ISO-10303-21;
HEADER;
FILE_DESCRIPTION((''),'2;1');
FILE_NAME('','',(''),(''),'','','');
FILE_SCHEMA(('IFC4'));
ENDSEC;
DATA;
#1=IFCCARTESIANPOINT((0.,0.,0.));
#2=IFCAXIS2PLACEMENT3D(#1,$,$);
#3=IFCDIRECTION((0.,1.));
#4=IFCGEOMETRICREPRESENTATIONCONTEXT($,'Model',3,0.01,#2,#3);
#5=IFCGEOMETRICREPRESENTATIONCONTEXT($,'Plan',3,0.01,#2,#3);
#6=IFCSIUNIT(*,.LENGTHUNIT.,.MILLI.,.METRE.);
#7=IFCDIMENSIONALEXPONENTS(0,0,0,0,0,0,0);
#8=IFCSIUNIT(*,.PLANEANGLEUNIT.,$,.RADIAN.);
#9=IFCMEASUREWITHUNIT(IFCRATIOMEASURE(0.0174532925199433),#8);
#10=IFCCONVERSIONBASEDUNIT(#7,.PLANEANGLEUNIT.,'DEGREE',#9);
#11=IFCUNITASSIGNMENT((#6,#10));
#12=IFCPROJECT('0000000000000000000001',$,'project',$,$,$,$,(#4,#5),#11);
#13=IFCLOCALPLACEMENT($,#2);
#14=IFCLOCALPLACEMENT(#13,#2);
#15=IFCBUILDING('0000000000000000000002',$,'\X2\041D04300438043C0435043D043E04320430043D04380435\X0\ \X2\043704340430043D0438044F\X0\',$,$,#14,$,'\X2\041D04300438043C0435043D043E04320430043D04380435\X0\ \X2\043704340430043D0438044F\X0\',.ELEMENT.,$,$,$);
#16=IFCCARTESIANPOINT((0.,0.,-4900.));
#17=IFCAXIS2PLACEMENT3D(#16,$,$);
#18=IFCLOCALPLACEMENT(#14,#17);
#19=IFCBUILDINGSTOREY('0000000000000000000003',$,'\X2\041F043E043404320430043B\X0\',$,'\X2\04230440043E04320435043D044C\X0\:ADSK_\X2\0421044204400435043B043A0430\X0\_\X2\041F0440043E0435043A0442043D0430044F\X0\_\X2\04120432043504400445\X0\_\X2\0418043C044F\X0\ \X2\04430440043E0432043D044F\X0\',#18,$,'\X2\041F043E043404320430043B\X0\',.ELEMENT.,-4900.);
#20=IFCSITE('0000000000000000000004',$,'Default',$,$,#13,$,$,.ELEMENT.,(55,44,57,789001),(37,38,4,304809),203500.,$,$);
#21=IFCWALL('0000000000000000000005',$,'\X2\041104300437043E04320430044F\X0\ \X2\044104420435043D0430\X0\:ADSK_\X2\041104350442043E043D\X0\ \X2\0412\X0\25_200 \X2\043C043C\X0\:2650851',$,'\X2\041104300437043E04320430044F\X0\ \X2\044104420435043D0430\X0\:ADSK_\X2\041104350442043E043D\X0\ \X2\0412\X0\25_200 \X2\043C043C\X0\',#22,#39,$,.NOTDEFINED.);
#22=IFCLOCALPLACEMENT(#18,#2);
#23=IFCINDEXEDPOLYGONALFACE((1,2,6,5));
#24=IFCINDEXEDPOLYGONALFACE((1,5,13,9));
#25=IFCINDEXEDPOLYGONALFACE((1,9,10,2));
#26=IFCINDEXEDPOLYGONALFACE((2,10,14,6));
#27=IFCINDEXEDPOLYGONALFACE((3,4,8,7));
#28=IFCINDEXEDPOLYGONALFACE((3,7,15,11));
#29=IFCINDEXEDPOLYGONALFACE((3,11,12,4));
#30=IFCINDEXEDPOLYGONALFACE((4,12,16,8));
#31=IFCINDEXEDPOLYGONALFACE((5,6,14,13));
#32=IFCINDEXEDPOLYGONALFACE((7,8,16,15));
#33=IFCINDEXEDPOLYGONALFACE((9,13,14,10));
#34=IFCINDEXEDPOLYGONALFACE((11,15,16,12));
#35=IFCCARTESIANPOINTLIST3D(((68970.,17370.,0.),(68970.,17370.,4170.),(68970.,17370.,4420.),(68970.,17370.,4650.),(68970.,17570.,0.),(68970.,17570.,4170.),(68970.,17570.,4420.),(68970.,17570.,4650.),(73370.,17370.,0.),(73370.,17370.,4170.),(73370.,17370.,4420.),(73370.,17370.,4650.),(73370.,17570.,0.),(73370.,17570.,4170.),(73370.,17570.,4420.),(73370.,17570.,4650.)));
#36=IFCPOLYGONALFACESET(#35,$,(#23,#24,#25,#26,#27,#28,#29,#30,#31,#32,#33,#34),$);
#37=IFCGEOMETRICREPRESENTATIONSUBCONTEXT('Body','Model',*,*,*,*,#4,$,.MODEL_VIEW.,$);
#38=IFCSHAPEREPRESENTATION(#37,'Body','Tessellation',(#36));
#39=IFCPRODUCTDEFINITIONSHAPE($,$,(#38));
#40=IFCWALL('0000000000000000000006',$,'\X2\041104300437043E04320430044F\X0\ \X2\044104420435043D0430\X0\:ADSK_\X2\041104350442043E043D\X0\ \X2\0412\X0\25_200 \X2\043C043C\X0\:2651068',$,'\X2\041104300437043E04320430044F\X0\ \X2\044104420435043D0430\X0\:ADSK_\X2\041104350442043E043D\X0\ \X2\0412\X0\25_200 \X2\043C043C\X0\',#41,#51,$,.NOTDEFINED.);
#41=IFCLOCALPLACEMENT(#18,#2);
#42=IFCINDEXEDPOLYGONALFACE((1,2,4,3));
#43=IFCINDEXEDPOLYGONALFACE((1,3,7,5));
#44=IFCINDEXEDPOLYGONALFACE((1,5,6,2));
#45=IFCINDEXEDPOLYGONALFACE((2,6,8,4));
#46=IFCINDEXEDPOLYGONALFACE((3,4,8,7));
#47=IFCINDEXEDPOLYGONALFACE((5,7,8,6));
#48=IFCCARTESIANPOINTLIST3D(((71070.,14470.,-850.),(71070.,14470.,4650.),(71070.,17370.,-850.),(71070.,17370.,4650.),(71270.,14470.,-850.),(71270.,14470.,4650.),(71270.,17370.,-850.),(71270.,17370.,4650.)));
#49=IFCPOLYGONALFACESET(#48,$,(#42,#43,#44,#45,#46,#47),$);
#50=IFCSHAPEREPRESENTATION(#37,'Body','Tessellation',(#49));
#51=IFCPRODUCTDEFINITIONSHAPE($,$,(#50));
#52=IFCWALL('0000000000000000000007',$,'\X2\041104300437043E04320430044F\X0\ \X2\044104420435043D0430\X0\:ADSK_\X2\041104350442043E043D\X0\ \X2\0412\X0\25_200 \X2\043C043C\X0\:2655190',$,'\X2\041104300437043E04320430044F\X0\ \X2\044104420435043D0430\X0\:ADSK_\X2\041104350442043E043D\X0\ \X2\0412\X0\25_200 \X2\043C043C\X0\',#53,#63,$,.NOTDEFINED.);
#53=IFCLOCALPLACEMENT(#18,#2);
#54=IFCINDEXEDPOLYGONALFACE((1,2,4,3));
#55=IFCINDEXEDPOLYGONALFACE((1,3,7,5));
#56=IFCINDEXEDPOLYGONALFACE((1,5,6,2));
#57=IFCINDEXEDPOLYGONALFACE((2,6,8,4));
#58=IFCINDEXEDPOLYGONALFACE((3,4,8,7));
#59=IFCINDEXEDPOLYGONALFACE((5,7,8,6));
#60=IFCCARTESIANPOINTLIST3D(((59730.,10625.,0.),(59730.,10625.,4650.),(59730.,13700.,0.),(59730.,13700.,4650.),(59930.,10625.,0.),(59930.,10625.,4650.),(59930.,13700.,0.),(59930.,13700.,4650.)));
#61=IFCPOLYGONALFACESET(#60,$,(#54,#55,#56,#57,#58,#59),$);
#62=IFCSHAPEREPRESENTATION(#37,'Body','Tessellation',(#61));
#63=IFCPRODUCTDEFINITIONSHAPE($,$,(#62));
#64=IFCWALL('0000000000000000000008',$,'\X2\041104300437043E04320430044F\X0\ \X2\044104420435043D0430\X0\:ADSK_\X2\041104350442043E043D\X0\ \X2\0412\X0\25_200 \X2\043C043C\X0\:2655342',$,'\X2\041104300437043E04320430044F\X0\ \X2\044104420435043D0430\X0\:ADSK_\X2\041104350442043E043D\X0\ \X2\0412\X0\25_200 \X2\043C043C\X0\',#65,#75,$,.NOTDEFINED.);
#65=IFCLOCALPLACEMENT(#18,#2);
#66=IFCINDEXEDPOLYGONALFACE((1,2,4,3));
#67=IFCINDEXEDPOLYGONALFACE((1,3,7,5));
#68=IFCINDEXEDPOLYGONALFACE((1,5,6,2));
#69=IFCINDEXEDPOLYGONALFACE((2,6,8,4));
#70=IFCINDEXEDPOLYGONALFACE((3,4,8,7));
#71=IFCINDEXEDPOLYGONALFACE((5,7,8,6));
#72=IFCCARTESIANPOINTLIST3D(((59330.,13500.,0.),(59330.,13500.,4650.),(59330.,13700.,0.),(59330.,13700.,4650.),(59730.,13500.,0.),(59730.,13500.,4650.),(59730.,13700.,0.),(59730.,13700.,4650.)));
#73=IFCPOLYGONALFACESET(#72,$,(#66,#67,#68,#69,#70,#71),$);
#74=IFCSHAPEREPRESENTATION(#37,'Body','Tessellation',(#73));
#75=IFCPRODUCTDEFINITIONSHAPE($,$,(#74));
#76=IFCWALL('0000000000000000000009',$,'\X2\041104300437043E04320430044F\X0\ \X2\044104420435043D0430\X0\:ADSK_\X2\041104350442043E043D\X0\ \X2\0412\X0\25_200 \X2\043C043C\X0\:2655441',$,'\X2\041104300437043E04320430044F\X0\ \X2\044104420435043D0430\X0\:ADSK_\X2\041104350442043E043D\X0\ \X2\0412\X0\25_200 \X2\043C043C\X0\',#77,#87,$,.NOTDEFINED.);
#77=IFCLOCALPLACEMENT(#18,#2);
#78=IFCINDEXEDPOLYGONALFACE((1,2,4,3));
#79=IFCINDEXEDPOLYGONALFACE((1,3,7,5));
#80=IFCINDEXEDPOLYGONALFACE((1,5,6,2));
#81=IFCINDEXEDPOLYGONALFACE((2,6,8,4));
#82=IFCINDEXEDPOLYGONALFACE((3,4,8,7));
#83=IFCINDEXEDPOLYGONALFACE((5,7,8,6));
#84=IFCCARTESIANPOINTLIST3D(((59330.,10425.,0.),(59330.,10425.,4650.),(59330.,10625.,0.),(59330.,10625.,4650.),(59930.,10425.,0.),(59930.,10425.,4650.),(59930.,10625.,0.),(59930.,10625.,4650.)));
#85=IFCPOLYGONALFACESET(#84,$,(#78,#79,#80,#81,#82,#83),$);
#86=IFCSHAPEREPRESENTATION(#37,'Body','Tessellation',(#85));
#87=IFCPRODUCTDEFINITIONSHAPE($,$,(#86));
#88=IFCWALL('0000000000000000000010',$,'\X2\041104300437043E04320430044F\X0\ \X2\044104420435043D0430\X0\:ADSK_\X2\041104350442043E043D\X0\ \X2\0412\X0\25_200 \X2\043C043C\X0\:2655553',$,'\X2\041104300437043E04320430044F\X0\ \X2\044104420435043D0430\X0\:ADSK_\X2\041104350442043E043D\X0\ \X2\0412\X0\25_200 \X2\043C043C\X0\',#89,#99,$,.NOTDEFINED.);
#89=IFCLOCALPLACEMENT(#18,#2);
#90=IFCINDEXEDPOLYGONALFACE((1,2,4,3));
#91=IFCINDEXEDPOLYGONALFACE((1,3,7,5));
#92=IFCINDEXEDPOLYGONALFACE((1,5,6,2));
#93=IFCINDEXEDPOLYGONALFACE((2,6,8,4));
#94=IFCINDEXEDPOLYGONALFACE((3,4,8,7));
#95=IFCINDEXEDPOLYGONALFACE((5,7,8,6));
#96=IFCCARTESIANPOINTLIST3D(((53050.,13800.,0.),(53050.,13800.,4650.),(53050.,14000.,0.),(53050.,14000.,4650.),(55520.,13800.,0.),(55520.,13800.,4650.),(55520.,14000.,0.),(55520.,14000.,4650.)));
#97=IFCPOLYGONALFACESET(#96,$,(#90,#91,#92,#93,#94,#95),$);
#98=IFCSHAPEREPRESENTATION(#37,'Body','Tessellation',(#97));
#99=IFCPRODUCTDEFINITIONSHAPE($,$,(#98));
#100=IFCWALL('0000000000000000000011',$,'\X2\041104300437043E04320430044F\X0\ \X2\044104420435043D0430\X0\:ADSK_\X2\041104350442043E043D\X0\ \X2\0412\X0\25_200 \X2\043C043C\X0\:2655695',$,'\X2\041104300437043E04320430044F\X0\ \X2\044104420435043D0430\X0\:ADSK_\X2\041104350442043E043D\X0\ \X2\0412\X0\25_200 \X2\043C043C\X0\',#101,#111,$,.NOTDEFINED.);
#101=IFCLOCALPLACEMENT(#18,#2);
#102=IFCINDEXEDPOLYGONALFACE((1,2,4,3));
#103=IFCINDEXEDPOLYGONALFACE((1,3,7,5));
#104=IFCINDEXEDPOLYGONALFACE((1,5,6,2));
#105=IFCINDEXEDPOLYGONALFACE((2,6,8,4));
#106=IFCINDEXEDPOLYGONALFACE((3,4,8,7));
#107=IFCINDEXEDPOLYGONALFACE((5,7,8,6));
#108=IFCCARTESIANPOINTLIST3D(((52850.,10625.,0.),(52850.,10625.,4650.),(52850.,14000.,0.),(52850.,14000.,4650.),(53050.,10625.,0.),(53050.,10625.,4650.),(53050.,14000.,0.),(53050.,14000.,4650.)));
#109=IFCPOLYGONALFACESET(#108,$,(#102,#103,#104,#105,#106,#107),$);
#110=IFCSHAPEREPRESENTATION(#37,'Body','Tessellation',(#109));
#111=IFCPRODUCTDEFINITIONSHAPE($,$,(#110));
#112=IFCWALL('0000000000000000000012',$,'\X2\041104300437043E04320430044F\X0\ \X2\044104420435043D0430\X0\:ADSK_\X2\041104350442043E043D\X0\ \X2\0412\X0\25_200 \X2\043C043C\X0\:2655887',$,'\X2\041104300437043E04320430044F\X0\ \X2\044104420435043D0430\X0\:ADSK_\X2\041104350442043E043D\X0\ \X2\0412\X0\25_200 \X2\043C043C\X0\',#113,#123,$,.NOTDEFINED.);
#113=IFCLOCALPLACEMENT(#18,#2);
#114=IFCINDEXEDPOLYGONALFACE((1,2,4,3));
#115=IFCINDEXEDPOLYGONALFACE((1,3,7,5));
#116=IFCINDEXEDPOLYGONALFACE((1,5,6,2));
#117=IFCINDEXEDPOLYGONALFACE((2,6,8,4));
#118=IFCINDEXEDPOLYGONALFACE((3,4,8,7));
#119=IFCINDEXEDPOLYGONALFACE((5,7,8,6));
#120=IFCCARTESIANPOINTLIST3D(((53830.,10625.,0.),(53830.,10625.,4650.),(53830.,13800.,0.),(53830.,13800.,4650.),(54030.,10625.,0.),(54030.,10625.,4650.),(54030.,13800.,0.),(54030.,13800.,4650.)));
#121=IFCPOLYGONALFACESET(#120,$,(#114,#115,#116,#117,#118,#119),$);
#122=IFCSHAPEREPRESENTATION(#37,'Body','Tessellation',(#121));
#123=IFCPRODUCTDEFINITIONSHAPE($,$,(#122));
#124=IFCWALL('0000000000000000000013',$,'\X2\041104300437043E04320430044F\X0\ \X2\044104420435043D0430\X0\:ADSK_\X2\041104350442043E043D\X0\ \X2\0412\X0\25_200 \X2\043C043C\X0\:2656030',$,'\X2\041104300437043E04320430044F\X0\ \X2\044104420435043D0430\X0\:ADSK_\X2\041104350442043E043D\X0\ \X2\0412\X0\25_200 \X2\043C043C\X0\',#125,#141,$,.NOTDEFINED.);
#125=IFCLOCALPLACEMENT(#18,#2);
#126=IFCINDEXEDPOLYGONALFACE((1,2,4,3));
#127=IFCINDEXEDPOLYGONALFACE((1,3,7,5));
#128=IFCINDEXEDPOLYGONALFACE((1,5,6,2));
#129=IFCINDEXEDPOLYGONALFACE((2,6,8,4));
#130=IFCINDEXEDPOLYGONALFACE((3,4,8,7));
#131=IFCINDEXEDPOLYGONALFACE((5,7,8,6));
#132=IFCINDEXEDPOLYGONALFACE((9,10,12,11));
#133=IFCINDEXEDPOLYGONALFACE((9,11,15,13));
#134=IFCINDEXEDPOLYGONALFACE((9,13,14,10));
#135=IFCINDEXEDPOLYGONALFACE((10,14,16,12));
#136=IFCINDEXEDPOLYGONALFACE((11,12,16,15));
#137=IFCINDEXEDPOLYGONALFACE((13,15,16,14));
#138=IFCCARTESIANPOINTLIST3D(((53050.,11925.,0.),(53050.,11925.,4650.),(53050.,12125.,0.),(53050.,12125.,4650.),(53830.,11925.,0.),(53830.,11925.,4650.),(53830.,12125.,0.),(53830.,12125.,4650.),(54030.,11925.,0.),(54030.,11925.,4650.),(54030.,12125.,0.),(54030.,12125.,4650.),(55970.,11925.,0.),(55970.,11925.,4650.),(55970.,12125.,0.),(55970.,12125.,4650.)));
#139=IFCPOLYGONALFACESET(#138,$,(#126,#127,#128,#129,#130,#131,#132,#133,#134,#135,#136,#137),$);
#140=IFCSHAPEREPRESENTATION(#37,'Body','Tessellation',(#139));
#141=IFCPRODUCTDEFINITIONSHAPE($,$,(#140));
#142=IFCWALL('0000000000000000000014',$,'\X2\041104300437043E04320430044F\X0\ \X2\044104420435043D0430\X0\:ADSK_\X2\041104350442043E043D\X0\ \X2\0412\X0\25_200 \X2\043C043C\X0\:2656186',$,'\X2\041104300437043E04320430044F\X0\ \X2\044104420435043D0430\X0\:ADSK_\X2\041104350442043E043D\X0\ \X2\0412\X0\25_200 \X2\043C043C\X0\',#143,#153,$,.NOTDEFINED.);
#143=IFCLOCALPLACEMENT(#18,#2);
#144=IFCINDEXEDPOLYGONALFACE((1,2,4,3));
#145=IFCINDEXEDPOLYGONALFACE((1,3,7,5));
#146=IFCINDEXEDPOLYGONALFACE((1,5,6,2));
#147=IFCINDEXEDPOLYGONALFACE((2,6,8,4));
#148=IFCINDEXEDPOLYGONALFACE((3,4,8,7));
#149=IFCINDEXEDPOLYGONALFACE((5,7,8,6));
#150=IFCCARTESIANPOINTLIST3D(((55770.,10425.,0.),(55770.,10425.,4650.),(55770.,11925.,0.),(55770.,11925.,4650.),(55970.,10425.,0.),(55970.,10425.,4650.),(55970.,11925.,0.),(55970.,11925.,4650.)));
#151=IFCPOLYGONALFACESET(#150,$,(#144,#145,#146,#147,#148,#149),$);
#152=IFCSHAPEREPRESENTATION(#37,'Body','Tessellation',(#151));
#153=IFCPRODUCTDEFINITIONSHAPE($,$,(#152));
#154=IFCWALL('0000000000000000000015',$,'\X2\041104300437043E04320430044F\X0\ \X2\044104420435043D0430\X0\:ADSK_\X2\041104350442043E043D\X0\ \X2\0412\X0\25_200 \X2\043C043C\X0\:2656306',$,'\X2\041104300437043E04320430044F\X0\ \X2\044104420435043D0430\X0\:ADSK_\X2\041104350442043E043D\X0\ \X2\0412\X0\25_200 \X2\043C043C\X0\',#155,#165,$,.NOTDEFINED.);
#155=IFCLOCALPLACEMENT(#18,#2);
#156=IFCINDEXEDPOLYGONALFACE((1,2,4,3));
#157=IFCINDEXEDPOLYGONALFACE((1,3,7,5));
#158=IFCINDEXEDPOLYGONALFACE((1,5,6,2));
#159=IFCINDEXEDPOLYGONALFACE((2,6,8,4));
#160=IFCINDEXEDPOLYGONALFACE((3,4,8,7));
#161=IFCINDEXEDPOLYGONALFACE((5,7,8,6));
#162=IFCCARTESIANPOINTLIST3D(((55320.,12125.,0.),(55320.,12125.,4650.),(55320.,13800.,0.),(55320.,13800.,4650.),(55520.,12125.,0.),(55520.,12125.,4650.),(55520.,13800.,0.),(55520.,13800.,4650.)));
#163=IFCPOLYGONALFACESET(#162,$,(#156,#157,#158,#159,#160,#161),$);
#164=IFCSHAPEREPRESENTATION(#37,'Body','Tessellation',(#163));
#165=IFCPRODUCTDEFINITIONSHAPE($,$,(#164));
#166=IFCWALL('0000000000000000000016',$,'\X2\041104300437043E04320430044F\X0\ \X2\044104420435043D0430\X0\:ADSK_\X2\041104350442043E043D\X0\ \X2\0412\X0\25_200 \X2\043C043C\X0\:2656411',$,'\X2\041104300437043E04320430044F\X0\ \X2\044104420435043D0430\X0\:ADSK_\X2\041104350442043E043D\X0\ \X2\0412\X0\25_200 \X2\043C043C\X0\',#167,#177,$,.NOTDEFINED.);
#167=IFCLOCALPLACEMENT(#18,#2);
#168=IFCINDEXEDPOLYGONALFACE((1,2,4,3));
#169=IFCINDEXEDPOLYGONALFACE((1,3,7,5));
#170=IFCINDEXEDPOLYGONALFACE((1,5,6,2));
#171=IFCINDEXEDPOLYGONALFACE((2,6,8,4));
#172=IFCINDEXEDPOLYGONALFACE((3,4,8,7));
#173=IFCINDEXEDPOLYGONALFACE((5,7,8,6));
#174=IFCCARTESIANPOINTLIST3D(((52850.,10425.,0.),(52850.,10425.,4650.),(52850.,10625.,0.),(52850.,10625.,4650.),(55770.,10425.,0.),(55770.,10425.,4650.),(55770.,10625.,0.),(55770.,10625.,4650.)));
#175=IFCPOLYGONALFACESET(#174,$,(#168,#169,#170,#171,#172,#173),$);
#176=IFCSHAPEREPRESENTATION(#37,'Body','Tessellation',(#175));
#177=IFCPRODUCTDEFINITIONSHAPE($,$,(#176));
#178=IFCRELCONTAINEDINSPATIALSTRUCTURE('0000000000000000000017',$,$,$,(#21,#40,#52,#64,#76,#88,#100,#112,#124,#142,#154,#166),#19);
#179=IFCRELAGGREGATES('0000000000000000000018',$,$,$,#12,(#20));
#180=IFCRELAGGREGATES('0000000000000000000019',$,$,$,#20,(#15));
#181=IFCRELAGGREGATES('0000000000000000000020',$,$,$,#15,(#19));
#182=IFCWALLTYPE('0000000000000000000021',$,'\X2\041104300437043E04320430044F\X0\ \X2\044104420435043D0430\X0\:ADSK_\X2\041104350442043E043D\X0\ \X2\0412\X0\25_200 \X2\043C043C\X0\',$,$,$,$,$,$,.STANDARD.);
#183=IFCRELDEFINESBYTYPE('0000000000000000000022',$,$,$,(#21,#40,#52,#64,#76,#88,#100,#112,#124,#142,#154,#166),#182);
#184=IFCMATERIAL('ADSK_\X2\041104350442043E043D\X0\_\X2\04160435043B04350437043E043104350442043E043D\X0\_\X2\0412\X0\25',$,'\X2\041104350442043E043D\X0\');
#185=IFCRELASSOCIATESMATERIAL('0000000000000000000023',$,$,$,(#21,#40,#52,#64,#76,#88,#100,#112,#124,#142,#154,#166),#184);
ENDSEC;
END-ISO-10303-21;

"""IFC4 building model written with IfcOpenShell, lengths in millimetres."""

from ifc_helpers import new_model, entity, si_unit, converted_unit, direction, frame, origin, place, context, subcontext, project, spatial, indexed_curve, outline, extrude, material, type_object, element, save


model = new_model("IFC4")

# Units and contexts
model_context = context("Model", 3, precision=0.01, world=origin(), true_north=direction((0.0, 1.0)))
plan_context = context("Plan", 3, precision=0.01, world=origin(), true_north=direction((0.0, 1.0)))
body_context = subcontext(model_context, "Body", "Model", "MODEL_VIEW")
ifc_project = project(units=[si_unit("LENGTHUNIT", "METRE", prefix="MILLI"), converted_unit("PLANEANGLEUNIT", "DEGREE", entity("IfcRatioMeasure", 0.0174532925199433), si_unit("PLANEANGLEUNIT", "RADIAN"), dimensions=[0, 0, 0, 0, 0, 0, 0])], contexts=[model_context, plan_context])

# Site, building, storey
site_placement = place(None, origin())
site = spatial("IfcSite", under=ifc_project, at=site_placement, Name="Default", CompositionType="ELEMENT", RefLatitude=(55, 44, 57, 789001), RefLongitude=(37, 38, 4, 304809), RefElevation=203500.0)
building_placement = place(site_placement, origin())
building = spatial("IfcBuilding", under=site, at=building_placement, Name="Наименование здания", LongName="Наименование здания", CompositionType="ELEMENT")
storey_placement = place(building_placement, frame((0.0, 0.0, -4900.0)))
storey = spatial("IfcBuildingStorey", under=building, at=storey_placement, Name="Подвал", ObjectType="Уровень:ADSK_Стрелка_Проектная_Вверх_Имя уровня", LongName="Подвал", CompositionType="ELEMENT", Elevation=-4900.0)

# Wall, opening
ifc_material = material(Name="ADSK_Бетон_Железобетон_В25", Category="Бетон")
wall_type_1 = type_object("IfcWallType", Name="Базовая стена:ADSK_Бетон В25_200 мм", PredefinedType="STANDARD")
placement_1 = place(storey_placement, frame((73370.0, 17470.0, 0.0), z_axis=(0.0, 0.0, 1.0), x_axis=(-1.0, 0.0, 0.0)))
wall_1 = element("IfcWall", 1, at=placement_1, inside=storey, type_object=wall_type_1, material=ifc_material, Name="Базовая стена:ADSK_Бетон В25_200 мм:2650851", ObjectType="Базовая стена:ADSK_Бетон В25_200 мм", PredefinedType="NOTDEFINED", context=body_context, shape_type="SweptSolid", body=[
    extrude(outline(indexed_curve([(4400.0, 100.0), (0.0, 100.0), (0.0, -100.0), (4400.0, -100.0), (4400.0, 100.0)], self_intersect=False)), origin(), (0.0, 0.0, 1.0), 4650.0),
])
element("IfcOpeningElement", 2, at=placement_1, cuts=wall_1, PredefinedType="OPENING", context=body_context, shape_type="SweptSolid", body=[
    extrude(outline(indexed_curve([(-2200.0, -100.0), (2200.0, -100.0), (2200.0, 100.0), (-2200.0, 100.0), (-2200.0, -100.0)], self_intersect=False)), frame((2200.0, 0.0, 4170.0)), (0.0, 0.0, 1.0), 250.0),
])

# Walls
wall_2_placement = place(storey_placement, frame((71170.0, 14470.0, -850.0), z_axis=(0.0, 0.0, 1.0), x_axis=(0.0, 1.0, 0.0)))
element("IfcWall", 3, at=wall_2_placement, inside=storey, type_object=wall_type_1, material=ifc_material, Name="Базовая стена:ADSK_Бетон В25_200 мм:2651068", ObjectType="Базовая стена:ADSK_Бетон В25_200 мм", PredefinedType="NOTDEFINED", context=body_context, shape_type="SweptSolid", body=[
    extrude(outline(indexed_curve([(2900.0, 100.0), (0.0, 100.0), (0.0, -100.0), (2900.0, -100.0), (2900.0, 100.0)], self_intersect=False)), origin(), (0.0, 0.0, 1.0), 5500.0),
])
wall_3_placement = place(storey_placement, frame((59830.0, 10625.0, 0.0), z_axis=(0.0, 0.0, 1.0), x_axis=(0.0, 1.0, 0.0)))
element("IfcWall", 4, at=wall_3_placement, inside=storey, type_object=wall_type_1, material=ifc_material, Name="Базовая стена:ADSK_Бетон В25_200 мм:2655190", ObjectType="Базовая стена:ADSK_Бетон В25_200 мм", PredefinedType="NOTDEFINED", context=body_context, shape_type="SweptSolid", body=[
    extrude(outline(indexed_curve([(3075.0, 100.0), (0.0, 100.0), (0.0, -100.0), (3075.0, -100.0), (3075.0, 100.0)], self_intersect=False)), origin(), (0.0, 0.0, 1.0), 4650.0),
])
wall_4_placement = place(storey_placement, frame((59730.0, 13600.0, 0.0), z_axis=(0.0, 0.0, 1.0), x_axis=(-1.0, 0.0, 0.0)))
element("IfcWall", 5, at=wall_4_placement, inside=storey, type_object=wall_type_1, material=ifc_material, Name="Базовая стена:ADSK_Бетон В25_200 мм:2655342", ObjectType="Базовая стена:ADSK_Бетон В25_200 мм", PredefinedType="NOTDEFINED", context=body_context, shape_type="SweptSolid", body=[
    extrude(outline(indexed_curve([(400.0, 100.0), (0.0, 100.0), (0.0, -100.0), (400.0, -100.0), (400.0, 100.0)], self_intersect=False)), origin(), (0.0, 0.0, 1.0), 4650.0),
])
wall_5_placement = place(storey_placement, frame((59930.0, 10525.0, 0.0), z_axis=(0.0, 0.0, 1.0), x_axis=(-1.0, 0.0, 0.0)))
element("IfcWall", 6, at=wall_5_placement, inside=storey, type_object=wall_type_1, material=ifc_material, Name="Базовая стена:ADSK_Бетон В25_200 мм:2655441", ObjectType="Базовая стена:ADSK_Бетон В25_200 мм", PredefinedType="NOTDEFINED", context=body_context, shape_type="SweptSolid", body=[
    extrude(outline(indexed_curve([(600.0, 100.0), (0.0, 100.0), (0.0, -100.0), (600.0, -100.0), (600.0, 100.0)], self_intersect=False)), origin(), (0.0, 0.0, 1.0), 4650.0),
])
wall_6_placement = place(storey_placement, frame((55520.0, 13900.0, 0.0), z_axis=(0.0, 0.0, 1.0), x_axis=(-1.0, 0.0, 0.0)))
element("IfcWall", 7, at=wall_6_placement, inside=storey, type_object=wall_type_1, material=ifc_material, Name="Базовая стена:ADSK_Бетон В25_200 мм:2655553", ObjectType="Базовая стена:ADSK_Бетон В25_200 мм", PredefinedType="NOTDEFINED", context=body_context, shape_type="SweptSolid", body=[
    extrude(outline(indexed_curve([(2470.0, 100.0), (0.0, 100.0), (0.0, -100.0), (2470.0, -100.0), (2470.0, 100.0)], self_intersect=False)), origin(), (0.0, 0.0, 1.0), 4650.0),
])
wall_7_placement = place(storey_placement, frame((52950.0, 14000.0, 0.0), z_axis=(0.0, 0.0, 1.0), x_axis=(0.0, -1.0, 0.0)))
element("IfcWall", 8, at=wall_7_placement, inside=storey, type_object=wall_type_1, material=ifc_material, Name="Базовая стена:ADSK_Бетон В25_200 мм:2655695", ObjectType="Базовая стена:ADSK_Бетон В25_200 мм", PredefinedType="NOTDEFINED", context=body_context, shape_type="SweptSolid", body=[
    extrude(outline(indexed_curve([(3375.0, 100.0), (0.0, 100.0), (0.0, -100.0), (3375.0, -100.0), (3375.0, 100.0)], self_intersect=False)), origin(), (0.0, 0.0, 1.0), 4650.0),
])
wall_8_placement = place(storey_placement, frame((53930.0, 13800.0, 0.0), z_axis=(0.0, 0.0, 1.0), x_axis=(0.0, -1.0, 0.0)))
element("IfcWall", 9, at=wall_8_placement, inside=storey, type_object=wall_type_1, material=ifc_material, Name="Базовая стена:ADSK_Бетон В25_200 мм:2655887", ObjectType="Базовая стена:ADSK_Бетон В25_200 мм", PredefinedType="NOTDEFINED", context=body_context, shape_type="SweptSolid", body=[
    extrude(outline(indexed_curve([(3175.0, 100.0), (0.0, 100.0), (0.0, -100.0), (3175.0, -100.0), (3175.0, 100.0)], self_intersect=False)), origin(), (0.0, 0.0, 1.0), 4650.0),
])

# Wall, opening
placement_2 = place(storey_placement, frame((53050.0, 12025.0, 0.0)))
wall_9 = element("IfcWall", 10, at=placement_2, inside=storey, type_object=wall_type_1, material=ifc_material, Name="Базовая стена:ADSK_Бетон В25_200 мм:2656030", ObjectType="Базовая стена:ADSK_Бетон В25_200 мм", PredefinedType="NOTDEFINED", context=body_context, shape_type="SweptSolid", body=[
    extrude(outline(indexed_curve([(2920.0, 100.0), (0.0, 100.0), (0.0, -100.0), (2920.0, -100.0), (2920.0, 100.0)], self_intersect=False)), origin(), (0.0, 0.0, 1.0), 4650.0),
])
element("IfcOpeningElement", 11, at=placement_2, cuts=wall_9, PredefinedType="OPENING", context=body_context, shape_type="SweptSolid", body=[
    extrude(outline(indexed_curve([(-2325.0, -100.0), (2325.0, -100.0), (2325.0, 100.0), (-2325.0, 100.0), (-2325.0, -100.0)], self_intersect=False)), frame((780.0, 0.0, 2325.0), z_axis=(1.0, 0.0, 0.0), x_axis=(0.0, 0.0, -1.0)), (0.0, 0.0, 1.0), 200.0),
])

# Walls
wall_10_placement = place(storey_placement, frame((55870.0, 11925.0, 0.0), z_axis=(0.0, 0.0, 1.0), x_axis=(0.0, -1.0, 0.0)))
element("IfcWall", 12, at=wall_10_placement, inside=storey, type_object=wall_type_1, material=ifc_material, Name="Базовая стена:ADSK_Бетон В25_200 мм:2656186", ObjectType="Базовая стена:ADSK_Бетон В25_200 мм", PredefinedType="NOTDEFINED", context=body_context, shape_type="SweptSolid", body=[
    extrude(outline(indexed_curve([(1500.0, 100.0), (0.0, 100.0), (0.0, -100.0), (1500.0, -100.0), (1500.0, 100.0)], self_intersect=False)), origin(), (0.0, 0.0, 1.0), 4650.0),
])
wall_11_placement = place(storey_placement, frame((55420.0, 13800.0, 0.0), z_axis=(0.0, 0.0, 1.0), x_axis=(0.0, -1.0, 0.0)))
element("IfcWall", 13, at=wall_11_placement, inside=storey, type_object=wall_type_1, material=ifc_material, Name="Базовая стена:ADSK_Бетон В25_200 мм:2656306", ObjectType="Базовая стена:ADSK_Бетон В25_200 мм", PredefinedType="NOTDEFINED", context=body_context, shape_type="SweptSolid", body=[
    extrude(outline(indexed_curve([(1675.0, 100.0), (0.0, 100.0), (0.0, -100.0), (1675.0, -100.0), (1675.0, 100.0)], self_intersect=False)), origin(), (0.0, 0.0, 1.0), 4650.0),
])
wall_12_placement = place(storey_placement, frame((55770.0, 10525.0, 0.0), z_axis=(0.0, 0.0, 1.0), x_axis=(-1.0, 0.0, 0.0)))
element("IfcWall", 14, at=wall_12_placement, inside=storey, type_object=wall_type_1, material=ifc_material, Name="Базовая стена:ADSK_Бетон В25_200 мм:2656411", ObjectType="Базовая стена:ADSK_Бетон В25_200 мм", PredefinedType="NOTDEFINED", context=body_context, shape_type="SweptSolid", body=[
    extrude(outline(indexed_curve([(2920.0, 100.0), (0.0, 100.0), (0.0, -100.0), (2920.0, -100.0), (2920.0, 100.0)], self_intersect=False)), origin(), (0.0, 0.0, 1.0), 4650.0),
])

save(model, "model.ifc")
